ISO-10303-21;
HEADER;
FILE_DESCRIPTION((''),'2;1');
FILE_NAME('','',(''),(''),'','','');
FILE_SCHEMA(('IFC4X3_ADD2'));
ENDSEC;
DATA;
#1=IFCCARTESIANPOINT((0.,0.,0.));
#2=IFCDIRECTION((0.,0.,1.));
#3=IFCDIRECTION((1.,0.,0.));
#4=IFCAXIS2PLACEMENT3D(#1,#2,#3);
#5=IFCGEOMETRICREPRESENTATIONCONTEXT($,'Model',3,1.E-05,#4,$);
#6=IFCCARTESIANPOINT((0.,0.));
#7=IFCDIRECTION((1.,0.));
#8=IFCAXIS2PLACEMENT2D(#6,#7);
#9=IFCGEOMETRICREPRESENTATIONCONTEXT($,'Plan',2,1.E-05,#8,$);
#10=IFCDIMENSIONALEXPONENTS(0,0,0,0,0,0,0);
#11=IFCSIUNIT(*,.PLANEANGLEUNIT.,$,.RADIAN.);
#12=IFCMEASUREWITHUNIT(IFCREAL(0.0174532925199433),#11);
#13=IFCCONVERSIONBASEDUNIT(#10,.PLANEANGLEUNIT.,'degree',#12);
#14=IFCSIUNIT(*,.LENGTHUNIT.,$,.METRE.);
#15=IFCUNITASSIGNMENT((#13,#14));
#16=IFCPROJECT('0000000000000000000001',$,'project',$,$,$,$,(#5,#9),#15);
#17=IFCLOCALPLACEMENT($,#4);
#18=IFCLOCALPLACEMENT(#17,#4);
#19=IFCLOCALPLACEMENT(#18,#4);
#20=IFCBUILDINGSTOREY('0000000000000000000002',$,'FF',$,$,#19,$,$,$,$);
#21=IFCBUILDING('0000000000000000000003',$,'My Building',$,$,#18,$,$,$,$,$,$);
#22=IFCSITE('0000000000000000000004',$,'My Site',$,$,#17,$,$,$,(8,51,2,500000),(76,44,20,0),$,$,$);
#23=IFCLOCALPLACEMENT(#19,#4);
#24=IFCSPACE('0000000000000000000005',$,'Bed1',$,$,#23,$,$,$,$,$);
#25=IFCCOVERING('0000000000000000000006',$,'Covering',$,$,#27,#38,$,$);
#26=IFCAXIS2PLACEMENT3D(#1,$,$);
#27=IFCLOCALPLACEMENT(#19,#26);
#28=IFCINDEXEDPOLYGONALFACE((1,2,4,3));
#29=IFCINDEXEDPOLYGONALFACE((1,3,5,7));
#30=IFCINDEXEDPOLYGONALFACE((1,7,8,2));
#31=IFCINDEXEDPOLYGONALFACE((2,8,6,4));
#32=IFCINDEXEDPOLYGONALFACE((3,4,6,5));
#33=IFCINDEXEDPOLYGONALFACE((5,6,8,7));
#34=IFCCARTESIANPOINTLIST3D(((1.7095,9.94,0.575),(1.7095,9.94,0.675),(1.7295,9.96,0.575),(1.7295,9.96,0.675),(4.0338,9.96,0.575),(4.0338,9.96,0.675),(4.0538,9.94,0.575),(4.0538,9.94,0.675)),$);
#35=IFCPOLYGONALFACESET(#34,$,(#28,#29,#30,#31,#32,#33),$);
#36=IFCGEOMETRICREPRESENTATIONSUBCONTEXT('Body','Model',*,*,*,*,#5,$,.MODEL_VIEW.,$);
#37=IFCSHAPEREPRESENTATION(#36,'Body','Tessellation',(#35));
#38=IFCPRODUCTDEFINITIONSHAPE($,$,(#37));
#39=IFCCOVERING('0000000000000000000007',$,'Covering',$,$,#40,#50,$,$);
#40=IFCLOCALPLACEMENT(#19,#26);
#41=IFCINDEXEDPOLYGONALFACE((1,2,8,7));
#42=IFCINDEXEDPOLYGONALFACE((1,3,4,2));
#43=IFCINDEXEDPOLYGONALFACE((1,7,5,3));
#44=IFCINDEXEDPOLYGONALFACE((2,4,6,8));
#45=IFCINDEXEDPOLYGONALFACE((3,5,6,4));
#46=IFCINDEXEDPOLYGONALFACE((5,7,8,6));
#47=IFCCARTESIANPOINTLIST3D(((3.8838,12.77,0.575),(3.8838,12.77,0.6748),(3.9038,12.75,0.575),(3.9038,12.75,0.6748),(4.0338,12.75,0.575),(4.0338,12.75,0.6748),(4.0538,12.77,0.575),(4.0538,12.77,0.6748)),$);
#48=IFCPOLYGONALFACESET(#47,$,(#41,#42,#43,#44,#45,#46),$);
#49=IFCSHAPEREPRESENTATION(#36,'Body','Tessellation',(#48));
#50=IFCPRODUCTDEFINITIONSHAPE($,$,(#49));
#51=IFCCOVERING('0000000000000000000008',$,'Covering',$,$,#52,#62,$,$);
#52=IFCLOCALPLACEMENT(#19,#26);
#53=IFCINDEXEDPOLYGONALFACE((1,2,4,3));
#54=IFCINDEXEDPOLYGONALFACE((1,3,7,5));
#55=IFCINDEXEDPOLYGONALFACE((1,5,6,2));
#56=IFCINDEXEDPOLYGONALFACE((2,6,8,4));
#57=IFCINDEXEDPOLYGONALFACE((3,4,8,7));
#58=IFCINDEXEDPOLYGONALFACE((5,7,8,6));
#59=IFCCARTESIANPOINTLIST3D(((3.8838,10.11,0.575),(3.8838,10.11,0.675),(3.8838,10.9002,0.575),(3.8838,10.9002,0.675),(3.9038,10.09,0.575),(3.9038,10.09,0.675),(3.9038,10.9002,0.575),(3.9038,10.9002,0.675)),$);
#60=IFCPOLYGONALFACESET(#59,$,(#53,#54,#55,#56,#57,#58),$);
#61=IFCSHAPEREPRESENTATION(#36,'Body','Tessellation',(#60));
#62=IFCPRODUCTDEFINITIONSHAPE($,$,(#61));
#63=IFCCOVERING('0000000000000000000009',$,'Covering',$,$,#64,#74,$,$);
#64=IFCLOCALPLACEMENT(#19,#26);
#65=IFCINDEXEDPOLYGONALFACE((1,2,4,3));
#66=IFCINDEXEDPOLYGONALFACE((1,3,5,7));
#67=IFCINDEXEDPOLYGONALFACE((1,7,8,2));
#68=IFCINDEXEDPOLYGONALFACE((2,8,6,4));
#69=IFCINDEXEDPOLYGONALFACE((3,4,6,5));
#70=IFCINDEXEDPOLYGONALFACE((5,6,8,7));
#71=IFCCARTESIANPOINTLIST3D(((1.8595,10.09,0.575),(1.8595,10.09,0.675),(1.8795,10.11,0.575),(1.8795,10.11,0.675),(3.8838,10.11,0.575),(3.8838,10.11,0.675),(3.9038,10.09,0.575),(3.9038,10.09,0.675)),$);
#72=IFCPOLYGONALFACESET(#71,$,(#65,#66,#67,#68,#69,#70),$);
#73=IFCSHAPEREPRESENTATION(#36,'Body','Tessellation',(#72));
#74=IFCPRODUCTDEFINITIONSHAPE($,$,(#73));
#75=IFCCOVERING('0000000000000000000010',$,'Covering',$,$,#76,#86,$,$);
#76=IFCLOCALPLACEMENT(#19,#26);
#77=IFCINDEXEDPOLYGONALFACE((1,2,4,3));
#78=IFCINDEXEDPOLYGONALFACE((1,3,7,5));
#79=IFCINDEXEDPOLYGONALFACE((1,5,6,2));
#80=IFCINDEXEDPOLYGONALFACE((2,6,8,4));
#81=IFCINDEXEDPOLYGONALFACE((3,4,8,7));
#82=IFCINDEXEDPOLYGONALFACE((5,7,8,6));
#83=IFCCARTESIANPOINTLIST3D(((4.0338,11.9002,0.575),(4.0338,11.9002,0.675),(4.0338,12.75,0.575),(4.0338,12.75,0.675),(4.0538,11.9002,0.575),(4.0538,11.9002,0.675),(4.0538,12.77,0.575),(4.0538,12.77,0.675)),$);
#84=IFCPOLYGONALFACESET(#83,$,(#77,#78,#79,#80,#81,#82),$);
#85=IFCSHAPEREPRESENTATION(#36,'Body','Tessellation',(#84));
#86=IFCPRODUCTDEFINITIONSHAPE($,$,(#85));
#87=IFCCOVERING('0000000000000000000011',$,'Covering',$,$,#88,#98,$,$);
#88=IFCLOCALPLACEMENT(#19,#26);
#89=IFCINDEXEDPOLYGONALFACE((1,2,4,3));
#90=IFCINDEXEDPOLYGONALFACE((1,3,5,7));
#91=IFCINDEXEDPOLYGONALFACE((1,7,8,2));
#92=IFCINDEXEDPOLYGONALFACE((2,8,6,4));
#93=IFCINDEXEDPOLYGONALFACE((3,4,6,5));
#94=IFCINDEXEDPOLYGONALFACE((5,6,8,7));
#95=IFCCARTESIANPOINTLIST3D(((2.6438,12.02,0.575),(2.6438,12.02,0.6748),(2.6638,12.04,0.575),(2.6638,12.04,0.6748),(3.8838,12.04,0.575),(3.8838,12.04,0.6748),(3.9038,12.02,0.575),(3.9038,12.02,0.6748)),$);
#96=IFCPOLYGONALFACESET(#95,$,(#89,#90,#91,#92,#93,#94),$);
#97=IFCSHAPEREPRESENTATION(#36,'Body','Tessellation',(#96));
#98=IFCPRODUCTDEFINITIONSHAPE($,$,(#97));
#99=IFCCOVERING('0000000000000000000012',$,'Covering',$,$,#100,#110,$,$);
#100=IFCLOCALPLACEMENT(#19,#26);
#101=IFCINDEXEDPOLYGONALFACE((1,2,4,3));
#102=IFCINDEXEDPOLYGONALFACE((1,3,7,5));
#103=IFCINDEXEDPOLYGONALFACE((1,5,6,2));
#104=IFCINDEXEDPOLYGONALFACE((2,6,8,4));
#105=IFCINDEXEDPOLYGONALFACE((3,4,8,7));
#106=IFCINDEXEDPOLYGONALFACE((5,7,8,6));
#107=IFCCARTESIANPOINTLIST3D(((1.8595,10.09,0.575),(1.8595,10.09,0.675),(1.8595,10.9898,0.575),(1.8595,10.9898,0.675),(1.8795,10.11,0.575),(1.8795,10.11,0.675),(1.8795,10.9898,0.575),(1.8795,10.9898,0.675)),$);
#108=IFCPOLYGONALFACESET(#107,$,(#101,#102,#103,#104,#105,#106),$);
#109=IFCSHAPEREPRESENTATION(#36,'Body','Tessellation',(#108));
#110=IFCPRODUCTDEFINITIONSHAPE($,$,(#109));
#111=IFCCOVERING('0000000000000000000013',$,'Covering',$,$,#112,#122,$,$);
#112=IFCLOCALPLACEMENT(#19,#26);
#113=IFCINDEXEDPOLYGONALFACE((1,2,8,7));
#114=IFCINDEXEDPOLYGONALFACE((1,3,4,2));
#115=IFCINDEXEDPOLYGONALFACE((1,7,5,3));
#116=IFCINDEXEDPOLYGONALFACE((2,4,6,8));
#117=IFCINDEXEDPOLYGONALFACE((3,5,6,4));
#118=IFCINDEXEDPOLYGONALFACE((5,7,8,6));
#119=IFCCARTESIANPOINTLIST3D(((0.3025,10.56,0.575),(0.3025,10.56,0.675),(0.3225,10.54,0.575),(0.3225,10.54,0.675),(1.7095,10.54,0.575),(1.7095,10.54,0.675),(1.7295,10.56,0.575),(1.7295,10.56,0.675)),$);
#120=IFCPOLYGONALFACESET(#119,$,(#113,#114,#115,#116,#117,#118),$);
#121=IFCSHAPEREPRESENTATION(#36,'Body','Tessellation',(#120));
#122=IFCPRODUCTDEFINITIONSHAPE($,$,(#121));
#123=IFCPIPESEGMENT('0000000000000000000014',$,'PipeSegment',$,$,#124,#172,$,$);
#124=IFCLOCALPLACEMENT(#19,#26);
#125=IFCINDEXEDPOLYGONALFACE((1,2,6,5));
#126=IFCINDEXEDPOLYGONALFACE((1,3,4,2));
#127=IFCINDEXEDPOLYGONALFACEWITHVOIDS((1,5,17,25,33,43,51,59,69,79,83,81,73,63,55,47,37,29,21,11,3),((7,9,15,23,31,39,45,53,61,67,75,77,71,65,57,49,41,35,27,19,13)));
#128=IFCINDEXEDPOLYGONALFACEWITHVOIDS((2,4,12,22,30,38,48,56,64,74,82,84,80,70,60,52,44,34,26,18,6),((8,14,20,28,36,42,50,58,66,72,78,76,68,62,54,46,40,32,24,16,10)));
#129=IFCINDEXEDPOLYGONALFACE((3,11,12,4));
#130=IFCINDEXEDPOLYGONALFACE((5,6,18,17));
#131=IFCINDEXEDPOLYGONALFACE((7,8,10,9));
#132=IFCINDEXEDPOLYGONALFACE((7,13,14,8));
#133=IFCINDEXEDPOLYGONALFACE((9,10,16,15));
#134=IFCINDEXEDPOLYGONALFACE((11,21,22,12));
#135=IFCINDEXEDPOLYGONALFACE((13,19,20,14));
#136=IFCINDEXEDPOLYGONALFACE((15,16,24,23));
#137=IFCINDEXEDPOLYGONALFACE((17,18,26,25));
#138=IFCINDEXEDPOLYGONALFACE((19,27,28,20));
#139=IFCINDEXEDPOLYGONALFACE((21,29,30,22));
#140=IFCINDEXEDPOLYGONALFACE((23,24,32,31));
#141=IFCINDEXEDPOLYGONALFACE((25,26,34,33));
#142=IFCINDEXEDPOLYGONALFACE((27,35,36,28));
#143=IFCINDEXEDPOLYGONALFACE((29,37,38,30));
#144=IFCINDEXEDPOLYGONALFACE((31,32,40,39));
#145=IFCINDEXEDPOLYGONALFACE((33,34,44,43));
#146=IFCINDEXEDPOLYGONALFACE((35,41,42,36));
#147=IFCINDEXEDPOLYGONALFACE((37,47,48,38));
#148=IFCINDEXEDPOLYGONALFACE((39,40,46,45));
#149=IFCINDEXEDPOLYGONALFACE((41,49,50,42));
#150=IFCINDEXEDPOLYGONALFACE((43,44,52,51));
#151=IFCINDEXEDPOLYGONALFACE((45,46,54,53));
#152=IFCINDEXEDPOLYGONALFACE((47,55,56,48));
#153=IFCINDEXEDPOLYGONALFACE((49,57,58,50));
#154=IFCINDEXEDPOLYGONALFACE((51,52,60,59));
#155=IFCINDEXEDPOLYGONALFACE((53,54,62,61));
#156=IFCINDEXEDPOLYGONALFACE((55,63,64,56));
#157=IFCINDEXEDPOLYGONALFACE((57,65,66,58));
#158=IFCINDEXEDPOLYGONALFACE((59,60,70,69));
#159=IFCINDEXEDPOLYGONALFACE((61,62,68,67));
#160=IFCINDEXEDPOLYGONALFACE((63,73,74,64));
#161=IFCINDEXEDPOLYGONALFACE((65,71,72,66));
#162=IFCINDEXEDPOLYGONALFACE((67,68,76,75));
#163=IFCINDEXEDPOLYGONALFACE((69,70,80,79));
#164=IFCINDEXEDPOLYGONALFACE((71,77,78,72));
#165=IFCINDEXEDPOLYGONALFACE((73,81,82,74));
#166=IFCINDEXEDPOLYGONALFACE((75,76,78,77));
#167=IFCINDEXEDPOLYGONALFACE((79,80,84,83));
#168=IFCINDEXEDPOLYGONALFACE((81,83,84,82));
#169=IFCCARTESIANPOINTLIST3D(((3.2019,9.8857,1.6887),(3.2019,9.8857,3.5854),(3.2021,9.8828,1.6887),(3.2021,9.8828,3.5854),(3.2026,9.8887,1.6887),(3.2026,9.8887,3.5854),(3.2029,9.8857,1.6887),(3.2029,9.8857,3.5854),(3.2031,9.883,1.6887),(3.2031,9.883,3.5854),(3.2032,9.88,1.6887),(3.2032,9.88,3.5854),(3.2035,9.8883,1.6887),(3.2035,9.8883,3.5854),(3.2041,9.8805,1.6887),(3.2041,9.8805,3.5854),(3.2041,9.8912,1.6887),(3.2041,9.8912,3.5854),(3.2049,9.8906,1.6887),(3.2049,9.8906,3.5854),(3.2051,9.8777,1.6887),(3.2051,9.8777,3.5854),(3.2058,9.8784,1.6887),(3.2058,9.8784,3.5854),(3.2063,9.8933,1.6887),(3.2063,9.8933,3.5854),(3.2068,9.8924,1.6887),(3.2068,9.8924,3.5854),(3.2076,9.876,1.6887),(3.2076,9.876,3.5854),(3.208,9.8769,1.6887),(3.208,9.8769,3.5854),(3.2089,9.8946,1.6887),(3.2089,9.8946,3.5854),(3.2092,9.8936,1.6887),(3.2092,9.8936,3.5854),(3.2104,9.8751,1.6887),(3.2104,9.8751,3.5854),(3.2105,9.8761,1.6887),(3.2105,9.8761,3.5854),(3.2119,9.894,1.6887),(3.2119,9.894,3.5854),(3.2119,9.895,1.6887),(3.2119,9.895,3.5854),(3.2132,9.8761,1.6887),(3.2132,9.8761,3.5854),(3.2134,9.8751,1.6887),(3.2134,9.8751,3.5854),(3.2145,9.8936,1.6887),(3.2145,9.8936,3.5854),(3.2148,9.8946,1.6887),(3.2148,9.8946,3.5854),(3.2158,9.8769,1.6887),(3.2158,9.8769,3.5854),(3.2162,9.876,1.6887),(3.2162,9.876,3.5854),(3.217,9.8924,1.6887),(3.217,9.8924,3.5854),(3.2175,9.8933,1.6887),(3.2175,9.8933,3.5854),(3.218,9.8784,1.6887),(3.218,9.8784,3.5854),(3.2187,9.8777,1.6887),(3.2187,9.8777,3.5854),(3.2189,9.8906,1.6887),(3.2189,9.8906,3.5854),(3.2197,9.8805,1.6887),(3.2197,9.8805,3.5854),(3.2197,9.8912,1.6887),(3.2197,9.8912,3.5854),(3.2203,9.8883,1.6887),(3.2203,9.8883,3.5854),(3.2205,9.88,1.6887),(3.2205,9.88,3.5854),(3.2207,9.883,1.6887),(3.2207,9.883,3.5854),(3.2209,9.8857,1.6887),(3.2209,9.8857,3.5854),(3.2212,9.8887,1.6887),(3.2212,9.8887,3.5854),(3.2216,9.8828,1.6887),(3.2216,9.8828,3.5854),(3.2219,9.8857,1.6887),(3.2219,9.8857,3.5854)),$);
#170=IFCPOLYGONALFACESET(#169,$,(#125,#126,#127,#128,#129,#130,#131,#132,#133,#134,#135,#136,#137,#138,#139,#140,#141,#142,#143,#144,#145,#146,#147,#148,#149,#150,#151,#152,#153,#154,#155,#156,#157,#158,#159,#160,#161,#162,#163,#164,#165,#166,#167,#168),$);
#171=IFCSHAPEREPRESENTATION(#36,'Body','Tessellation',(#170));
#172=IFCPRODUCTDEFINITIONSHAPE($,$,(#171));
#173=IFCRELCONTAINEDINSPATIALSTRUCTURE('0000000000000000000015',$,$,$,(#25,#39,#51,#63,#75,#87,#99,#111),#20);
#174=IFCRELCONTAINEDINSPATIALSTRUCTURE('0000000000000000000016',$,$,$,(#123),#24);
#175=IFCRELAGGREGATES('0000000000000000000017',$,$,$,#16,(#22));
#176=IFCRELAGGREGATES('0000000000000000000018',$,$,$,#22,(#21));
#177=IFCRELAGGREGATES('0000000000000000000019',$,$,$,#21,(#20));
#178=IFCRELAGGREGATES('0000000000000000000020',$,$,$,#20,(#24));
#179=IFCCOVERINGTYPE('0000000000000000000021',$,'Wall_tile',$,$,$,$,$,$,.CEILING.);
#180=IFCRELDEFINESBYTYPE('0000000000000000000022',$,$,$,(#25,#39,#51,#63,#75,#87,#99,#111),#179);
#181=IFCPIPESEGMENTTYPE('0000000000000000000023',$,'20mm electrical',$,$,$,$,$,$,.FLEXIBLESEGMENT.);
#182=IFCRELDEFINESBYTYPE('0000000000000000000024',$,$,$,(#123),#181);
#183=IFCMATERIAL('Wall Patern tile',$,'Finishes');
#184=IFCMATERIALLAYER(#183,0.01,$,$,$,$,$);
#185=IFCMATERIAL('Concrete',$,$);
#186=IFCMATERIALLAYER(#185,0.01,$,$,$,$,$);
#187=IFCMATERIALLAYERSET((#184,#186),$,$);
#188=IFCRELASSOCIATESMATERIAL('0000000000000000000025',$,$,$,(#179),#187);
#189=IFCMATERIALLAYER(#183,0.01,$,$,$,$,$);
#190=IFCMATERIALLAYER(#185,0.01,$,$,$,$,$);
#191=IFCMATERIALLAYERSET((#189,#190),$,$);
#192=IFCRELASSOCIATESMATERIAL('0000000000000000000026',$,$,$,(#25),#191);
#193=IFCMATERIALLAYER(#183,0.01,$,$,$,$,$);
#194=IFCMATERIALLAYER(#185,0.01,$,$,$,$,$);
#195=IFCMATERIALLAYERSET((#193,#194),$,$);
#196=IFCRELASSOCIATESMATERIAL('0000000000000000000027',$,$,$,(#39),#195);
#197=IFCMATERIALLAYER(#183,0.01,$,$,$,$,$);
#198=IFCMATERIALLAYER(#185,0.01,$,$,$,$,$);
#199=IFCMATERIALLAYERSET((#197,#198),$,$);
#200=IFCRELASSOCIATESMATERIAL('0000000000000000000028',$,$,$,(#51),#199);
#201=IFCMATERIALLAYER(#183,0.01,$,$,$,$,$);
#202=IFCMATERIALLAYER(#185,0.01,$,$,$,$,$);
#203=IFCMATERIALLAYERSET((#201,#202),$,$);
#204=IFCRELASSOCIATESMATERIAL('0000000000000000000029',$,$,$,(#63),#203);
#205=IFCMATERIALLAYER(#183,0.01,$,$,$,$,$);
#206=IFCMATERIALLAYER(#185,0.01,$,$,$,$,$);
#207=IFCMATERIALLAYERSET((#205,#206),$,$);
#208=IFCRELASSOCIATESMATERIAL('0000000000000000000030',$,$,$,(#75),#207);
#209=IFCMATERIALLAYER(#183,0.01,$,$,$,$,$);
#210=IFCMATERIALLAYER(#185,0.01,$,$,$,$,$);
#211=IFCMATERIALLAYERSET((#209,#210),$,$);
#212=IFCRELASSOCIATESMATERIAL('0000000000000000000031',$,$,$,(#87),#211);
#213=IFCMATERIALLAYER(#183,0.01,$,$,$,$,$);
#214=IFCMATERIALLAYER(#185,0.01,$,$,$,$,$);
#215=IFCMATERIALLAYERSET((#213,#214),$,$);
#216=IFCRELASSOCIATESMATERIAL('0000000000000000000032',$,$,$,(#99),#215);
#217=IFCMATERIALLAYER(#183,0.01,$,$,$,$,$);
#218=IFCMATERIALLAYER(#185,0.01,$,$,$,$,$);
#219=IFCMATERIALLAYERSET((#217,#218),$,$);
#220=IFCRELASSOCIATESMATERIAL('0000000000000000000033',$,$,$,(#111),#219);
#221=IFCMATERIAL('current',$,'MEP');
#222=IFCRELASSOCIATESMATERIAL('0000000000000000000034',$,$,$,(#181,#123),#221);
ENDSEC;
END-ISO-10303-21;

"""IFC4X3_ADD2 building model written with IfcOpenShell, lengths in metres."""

from ifc_helpers import new_model, entity, si_unit, converted_unit, frame, origin_with_axes, origin_2d_with_axis, place, context, subcontext, project, spatial, line, indexed_curve, hollow_circle, outline, extrude, material, layer, layer_set, layer_usage, material_profile, profile_set, profile_usage, type_object, element, save


model = new_model("IFC4X3_ADD2")

# Units and contexts
model_context = context("Model", 3, precision=1e-05, world=origin_with_axes())
plan_context = context("Plan", 2, precision=1e-05, world=origin_2d_with_axis())
body_context = subcontext(model_context, "Body", "Model", "MODEL_VIEW")
ifc_project = project(units=[converted_unit("PLANEANGLEUNIT", "degree", entity("IfcReal", 0.0174532925199433), si_unit("PLANEANGLEUNIT", "RADIAN"), dimensions=[0, 0, 0, 0, 0, 0, 0]), si_unit("LENGTHUNIT", "METRE")], contexts=[model_context, plan_context])

# Site, building, storey
site_placement = place(None, origin_with_axes())
site = spatial("IfcSite", under=ifc_project, at=site_placement, Name="My Site", RefLatitude=(8, 51, 2, 500000), RefLongitude=(76, 44, 20, 0))
building_placement = place(site_placement, origin_with_axes())
building = spatial("IfcBuilding", under=site, at=building_placement, Name="My Building")
storey_placement = place(building_placement, origin_with_axes())
storey = spatial("IfcBuildingStorey", under=building, at=storey_placement, Name="FF")

# Coverings
ifc_material_1 = material(Name="Wall Patern tile", Category="Finishes")
ifc_material_2 = material(Name="Concrete")
ifc_layer_1 = layer(ifc_material_1, 0.01)
ifc_layer_2 = layer(ifc_material_2, 0.01)
ifc_layer_set_1 = layer_set([ifc_layer_1, ifc_layer_2])
covering_type = type_object("IfcCoveringType", Name="Wall_tile", PredefinedType="CEILING", material=ifc_layer_set_1)
ifc_layer_3 = layer(ifc_material_1, 0.01)
ifc_layer_4 = layer(ifc_material_2, 0.01)
ifc_layer_set_2 = layer_set([ifc_layer_3, ifc_layer_4])
ifc_layer_usage_1 = layer_usage(ifc_layer_set_2, "AXIS2", "POSITIVE", 0.0)
covering_1_placement = place(storey_placement, frame((1.7095, 9.94, 0.575), z_axis=(0.0, 0.0, 1.0), x_axis=(1.0, 0.0, 0.0)))
element("IfcCovering", 1, at=covering_1_placement, inside=storey, type_object=covering_type, material=ifc_layer_usage_1, Name="Covering", context=body_context, shape_type="SweptSolid", body=[
    extrude(outline(indexed_curve([(0.0, 0.0), (0.02, 0.02), (2.3244, 0.02), (2.3444, 0.0)], segments=[line(1, 2, 3, 4, 1)])), origin_with_axes(), (0.0, 0.0, 1.0), 0.1),
])
ifc_layer_5 = layer(ifc_material_1, 0.01)
ifc_layer_6 = layer(ifc_material_2, 0.01)
ifc_layer_set_3 = layer_set([ifc_layer_5, ifc_layer_6])
ifc_layer_usage_2 = layer_usage(ifc_layer_set_3, "AXIS2", "POSITIVE", 0.0)
covering_2_placement = place(storey_placement, frame((4.0538, 12.77, 0.575), z_axis=(0.0, 0.0, 1.0), x_axis=(-1.0, 0.0, 0.0)))
element("IfcCovering", 2, at=covering_2_placement, inside=storey, type_object=covering_type, material=ifc_layer_usage_2, Name="Covering", context=body_context, shape_type="SweptSolid", body=[
    extrude(outline(indexed_curve([(0.0, 0.0), (0.02, 0.02), (0.15, 0.02), (0.17, 0.0)], segments=[line(1, 2, 3, 4, 1)])), origin_with_axes(), (0.0, 0.0, 1.0), 0.0998),
])
ifc_layer_7 = layer(ifc_material_1, 0.01)
ifc_layer_8 = layer(ifc_material_2, 0.01)
ifc_layer_set_4 = layer_set([ifc_layer_7, ifc_layer_8])
ifc_layer_usage_3 = layer_usage(ifc_layer_set_4, "AXIS2", "POSITIVE", 0.0)
covering_3_placement = place(storey_placement, frame((3.8838, 10.9002, 0.575), z_axis=(0.0, 0.0, 1.0), x_axis=(0.0, -1.0, 0.0)))
element("IfcCovering", 3, at=covering_3_placement, inside=storey, type_object=covering_type, material=ifc_layer_usage_3, Name="Covering", context=body_context, shape_type="SweptSolid", body=[
    extrude(outline(indexed_curve([(0.0, 0.0), (0.0, 0.02), (0.8102, 0.02), (0.7902, 0.0)], segments=[line(1, 2, 3, 4, 1)])), origin_with_axes(), (0.0, 0.0, 1.0), 0.1),
])
ifc_layer_9 = layer(ifc_material_1, 0.01)
ifc_layer_10 = layer(ifc_material_2, 0.01)
ifc_layer_set_5 = layer_set([ifc_layer_9, ifc_layer_10])
ifc_layer_usage_4 = layer_usage(ifc_layer_set_5, "AXIS2", "NEGATIVE", 0.0)
covering_4_placement = place(storey_placement, frame((1.8795, 10.11, 0.575), z_axis=(0.0, 0.0, 1.0), x_axis=(1.0, 0.0, 0.0)))
element("IfcCovering", 4, at=covering_4_placement, inside=storey, type_object=covering_type, material=ifc_layer_usage_4, Name="Covering", context=body_context, shape_type="SweptSolid", body=[
    extrude(outline(indexed_curve([(-0.02, -0.02), (0.0, 0.0), (2.0044, 0.0), (2.0244, -0.02)], segments=[line(1, 2, 3, 4, 1)])), origin_with_axes(), (0.0, 0.0, 1.0), 0.1),
])
ifc_layer_11 = layer(ifc_material_1, 0.01)
ifc_layer_12 = layer(ifc_material_2, 0.01)
ifc_layer_set_6 = layer_set([ifc_layer_11, ifc_layer_12])
ifc_layer_usage_5 = layer_usage(ifc_layer_set_6, "AXIS2", "NEGATIVE", 0.0)
covering_5_placement = place(storey_placement, frame((4.0538, 12.77, 0.575), z_axis=(0.0, 0.0, 1.0), x_axis=(0.0, -1.0, 0.0)))
element("IfcCovering", 5, at=covering_5_placement, inside=storey, type_object=covering_type, material=ifc_layer_usage_5, Name="Covering", context=body_context, shape_type="SweptSolid", body=[
    extrude(outline(indexed_curve([(0.02, -0.02), (0.0, 0.0), (0.8698, 0.0), (0.8698, -0.02)], segments=[line(1, 2, 3, 4, 1)])), origin_with_axes(), (0.0, 0.0, 1.0), 0.1),
])
ifc_layer_13 = layer(ifc_material_1, 0.01)
ifc_layer_14 = layer(ifc_material_2, 0.01)
ifc_layer_set_7 = layer_set([ifc_layer_13, ifc_layer_14])
ifc_layer_usage_6 = layer_usage(ifc_layer_set_7, "AXIS2", "POSITIVE", 0.0)
covering_6_placement = place(storey_placement, frame((3.8838, 12.04, 0.575), z_axis=(0.0, 0.0, 1.0), x_axis=(-1.0, 0.0, 0.0)))
element("IfcCovering", 6, at=covering_6_placement, inside=storey, type_object=covering_type, material=ifc_layer_usage_6, Name="Covering", context=body_context, shape_type="SweptSolid", body=[
    extrude(outline(indexed_curve([(0.0, 0.0), (-0.02, 0.02), (1.24, 0.02), (1.22, 0.0)], segments=[line(1, 2, 3, 4, 1)])), origin_with_axes(), (0.0, 0.0, 1.0), 0.0998),
])
ifc_layer_15 = layer(ifc_material_1, 0.01)
ifc_layer_16 = layer(ifc_material_2, 0.01)
ifc_layer_set_8 = layer_set([ifc_layer_15, ifc_layer_16])
ifc_layer_usage_7 = layer_usage(ifc_layer_set_8, "AXIS2", "NEGATIVE", 0.0)
covering_7_placement = place(storey_placement, frame((1.8795, 10.9898, 0.575), z_axis=(0.0, 0.0, 1.0), x_axis=(0.0, -1.0, 0.0)))
element("IfcCovering", 7, at=covering_7_placement, inside=storey, type_object=covering_type, material=ifc_layer_usage_7, Name="Covering", context=body_context, shape_type="SweptSolid", body=[
    extrude(outline(indexed_curve([(0.0, -0.02), (0.0, 0.0), (0.8798, 0.0), (0.8998, -0.02)], segments=[line(1, 2, 3, 4, 1)])), origin_with_axes(), (0.0, 0.0, 1.0), 0.1),
])
ifc_layer_17 = layer(ifc_material_1, 0.01)
ifc_layer_18 = layer(ifc_material_2, 0.01)
ifc_layer_set_9 = layer_set([ifc_layer_17, ifc_layer_18])
ifc_layer_usage_8 = layer_usage(ifc_layer_set_9, "AXIS2", "POSITIVE", 0.0)
covering_8_placement = place(storey_placement, frame((0.3025, 10.54, 0.575), z_axis=(0.0, 0.0, 1.0), x_axis=(1.0, 0.0, 0.0)))
element("IfcCovering", 8, at=covering_8_placement, inside=storey, type_object=covering_type, material=ifc_layer_usage_8, Name="Covering", context=body_context, shape_type="SweptSolid", body=[
    extrude(outline(indexed_curve([(0.02, 0.0), (0.0, 0.02), (1.427, 0.02), (1.407, 0.0)], segments=[line(1, 2, 3, 4, 1)])), origin_with_axes(), (0.0, 0.0, 1.0), 0.1),
])

# Shared definitions
space_placement = place(storey_placement, origin_with_axes())
space = spatial("IfcSpace", under=storey, at=space_placement, Name="Bed1")

# Pipe segment
ifc_material_3 = material(Name="current", Category="MEP")
ifc_material_profile = material_profile(ifc_material_3, hollow_circle(Radius=0.01, WallThickness=0.001))
ifc_profile_set = profile_set([ifc_material_profile], Name="current")
ifc_profile_usage_1 = profile_usage(ifc_profile_set, cardinal=5)
pipe_segment_type = type_object("IfcPipeSegmentType", Name="20mm electrical", PredefinedType="FLEXIBLESEGMENT", material=ifc_profile_set)
pipe_segment_1_placement = place(space_placement, frame((3.2119, 9.885, 1.6887), z_axis=(0.0, 0.0, 1.0), x_axis=(0.0, 1.0, 0.0)))
element("IfcPipeSegment", 9, at=pipe_segment_1_placement, inside=space, type_object=pipe_segment_type, material=ifc_profile_usage_1, Name="PipeSegment", context=body_context, shape_type="SweptSolid", body=[
    extrude(hollow_circle(Radius=0.01, WallThickness=0.001), origin_with_axes(), (0.0, 0.0, 1.0), 1.8967),
])

save(model, "model.ifc")
